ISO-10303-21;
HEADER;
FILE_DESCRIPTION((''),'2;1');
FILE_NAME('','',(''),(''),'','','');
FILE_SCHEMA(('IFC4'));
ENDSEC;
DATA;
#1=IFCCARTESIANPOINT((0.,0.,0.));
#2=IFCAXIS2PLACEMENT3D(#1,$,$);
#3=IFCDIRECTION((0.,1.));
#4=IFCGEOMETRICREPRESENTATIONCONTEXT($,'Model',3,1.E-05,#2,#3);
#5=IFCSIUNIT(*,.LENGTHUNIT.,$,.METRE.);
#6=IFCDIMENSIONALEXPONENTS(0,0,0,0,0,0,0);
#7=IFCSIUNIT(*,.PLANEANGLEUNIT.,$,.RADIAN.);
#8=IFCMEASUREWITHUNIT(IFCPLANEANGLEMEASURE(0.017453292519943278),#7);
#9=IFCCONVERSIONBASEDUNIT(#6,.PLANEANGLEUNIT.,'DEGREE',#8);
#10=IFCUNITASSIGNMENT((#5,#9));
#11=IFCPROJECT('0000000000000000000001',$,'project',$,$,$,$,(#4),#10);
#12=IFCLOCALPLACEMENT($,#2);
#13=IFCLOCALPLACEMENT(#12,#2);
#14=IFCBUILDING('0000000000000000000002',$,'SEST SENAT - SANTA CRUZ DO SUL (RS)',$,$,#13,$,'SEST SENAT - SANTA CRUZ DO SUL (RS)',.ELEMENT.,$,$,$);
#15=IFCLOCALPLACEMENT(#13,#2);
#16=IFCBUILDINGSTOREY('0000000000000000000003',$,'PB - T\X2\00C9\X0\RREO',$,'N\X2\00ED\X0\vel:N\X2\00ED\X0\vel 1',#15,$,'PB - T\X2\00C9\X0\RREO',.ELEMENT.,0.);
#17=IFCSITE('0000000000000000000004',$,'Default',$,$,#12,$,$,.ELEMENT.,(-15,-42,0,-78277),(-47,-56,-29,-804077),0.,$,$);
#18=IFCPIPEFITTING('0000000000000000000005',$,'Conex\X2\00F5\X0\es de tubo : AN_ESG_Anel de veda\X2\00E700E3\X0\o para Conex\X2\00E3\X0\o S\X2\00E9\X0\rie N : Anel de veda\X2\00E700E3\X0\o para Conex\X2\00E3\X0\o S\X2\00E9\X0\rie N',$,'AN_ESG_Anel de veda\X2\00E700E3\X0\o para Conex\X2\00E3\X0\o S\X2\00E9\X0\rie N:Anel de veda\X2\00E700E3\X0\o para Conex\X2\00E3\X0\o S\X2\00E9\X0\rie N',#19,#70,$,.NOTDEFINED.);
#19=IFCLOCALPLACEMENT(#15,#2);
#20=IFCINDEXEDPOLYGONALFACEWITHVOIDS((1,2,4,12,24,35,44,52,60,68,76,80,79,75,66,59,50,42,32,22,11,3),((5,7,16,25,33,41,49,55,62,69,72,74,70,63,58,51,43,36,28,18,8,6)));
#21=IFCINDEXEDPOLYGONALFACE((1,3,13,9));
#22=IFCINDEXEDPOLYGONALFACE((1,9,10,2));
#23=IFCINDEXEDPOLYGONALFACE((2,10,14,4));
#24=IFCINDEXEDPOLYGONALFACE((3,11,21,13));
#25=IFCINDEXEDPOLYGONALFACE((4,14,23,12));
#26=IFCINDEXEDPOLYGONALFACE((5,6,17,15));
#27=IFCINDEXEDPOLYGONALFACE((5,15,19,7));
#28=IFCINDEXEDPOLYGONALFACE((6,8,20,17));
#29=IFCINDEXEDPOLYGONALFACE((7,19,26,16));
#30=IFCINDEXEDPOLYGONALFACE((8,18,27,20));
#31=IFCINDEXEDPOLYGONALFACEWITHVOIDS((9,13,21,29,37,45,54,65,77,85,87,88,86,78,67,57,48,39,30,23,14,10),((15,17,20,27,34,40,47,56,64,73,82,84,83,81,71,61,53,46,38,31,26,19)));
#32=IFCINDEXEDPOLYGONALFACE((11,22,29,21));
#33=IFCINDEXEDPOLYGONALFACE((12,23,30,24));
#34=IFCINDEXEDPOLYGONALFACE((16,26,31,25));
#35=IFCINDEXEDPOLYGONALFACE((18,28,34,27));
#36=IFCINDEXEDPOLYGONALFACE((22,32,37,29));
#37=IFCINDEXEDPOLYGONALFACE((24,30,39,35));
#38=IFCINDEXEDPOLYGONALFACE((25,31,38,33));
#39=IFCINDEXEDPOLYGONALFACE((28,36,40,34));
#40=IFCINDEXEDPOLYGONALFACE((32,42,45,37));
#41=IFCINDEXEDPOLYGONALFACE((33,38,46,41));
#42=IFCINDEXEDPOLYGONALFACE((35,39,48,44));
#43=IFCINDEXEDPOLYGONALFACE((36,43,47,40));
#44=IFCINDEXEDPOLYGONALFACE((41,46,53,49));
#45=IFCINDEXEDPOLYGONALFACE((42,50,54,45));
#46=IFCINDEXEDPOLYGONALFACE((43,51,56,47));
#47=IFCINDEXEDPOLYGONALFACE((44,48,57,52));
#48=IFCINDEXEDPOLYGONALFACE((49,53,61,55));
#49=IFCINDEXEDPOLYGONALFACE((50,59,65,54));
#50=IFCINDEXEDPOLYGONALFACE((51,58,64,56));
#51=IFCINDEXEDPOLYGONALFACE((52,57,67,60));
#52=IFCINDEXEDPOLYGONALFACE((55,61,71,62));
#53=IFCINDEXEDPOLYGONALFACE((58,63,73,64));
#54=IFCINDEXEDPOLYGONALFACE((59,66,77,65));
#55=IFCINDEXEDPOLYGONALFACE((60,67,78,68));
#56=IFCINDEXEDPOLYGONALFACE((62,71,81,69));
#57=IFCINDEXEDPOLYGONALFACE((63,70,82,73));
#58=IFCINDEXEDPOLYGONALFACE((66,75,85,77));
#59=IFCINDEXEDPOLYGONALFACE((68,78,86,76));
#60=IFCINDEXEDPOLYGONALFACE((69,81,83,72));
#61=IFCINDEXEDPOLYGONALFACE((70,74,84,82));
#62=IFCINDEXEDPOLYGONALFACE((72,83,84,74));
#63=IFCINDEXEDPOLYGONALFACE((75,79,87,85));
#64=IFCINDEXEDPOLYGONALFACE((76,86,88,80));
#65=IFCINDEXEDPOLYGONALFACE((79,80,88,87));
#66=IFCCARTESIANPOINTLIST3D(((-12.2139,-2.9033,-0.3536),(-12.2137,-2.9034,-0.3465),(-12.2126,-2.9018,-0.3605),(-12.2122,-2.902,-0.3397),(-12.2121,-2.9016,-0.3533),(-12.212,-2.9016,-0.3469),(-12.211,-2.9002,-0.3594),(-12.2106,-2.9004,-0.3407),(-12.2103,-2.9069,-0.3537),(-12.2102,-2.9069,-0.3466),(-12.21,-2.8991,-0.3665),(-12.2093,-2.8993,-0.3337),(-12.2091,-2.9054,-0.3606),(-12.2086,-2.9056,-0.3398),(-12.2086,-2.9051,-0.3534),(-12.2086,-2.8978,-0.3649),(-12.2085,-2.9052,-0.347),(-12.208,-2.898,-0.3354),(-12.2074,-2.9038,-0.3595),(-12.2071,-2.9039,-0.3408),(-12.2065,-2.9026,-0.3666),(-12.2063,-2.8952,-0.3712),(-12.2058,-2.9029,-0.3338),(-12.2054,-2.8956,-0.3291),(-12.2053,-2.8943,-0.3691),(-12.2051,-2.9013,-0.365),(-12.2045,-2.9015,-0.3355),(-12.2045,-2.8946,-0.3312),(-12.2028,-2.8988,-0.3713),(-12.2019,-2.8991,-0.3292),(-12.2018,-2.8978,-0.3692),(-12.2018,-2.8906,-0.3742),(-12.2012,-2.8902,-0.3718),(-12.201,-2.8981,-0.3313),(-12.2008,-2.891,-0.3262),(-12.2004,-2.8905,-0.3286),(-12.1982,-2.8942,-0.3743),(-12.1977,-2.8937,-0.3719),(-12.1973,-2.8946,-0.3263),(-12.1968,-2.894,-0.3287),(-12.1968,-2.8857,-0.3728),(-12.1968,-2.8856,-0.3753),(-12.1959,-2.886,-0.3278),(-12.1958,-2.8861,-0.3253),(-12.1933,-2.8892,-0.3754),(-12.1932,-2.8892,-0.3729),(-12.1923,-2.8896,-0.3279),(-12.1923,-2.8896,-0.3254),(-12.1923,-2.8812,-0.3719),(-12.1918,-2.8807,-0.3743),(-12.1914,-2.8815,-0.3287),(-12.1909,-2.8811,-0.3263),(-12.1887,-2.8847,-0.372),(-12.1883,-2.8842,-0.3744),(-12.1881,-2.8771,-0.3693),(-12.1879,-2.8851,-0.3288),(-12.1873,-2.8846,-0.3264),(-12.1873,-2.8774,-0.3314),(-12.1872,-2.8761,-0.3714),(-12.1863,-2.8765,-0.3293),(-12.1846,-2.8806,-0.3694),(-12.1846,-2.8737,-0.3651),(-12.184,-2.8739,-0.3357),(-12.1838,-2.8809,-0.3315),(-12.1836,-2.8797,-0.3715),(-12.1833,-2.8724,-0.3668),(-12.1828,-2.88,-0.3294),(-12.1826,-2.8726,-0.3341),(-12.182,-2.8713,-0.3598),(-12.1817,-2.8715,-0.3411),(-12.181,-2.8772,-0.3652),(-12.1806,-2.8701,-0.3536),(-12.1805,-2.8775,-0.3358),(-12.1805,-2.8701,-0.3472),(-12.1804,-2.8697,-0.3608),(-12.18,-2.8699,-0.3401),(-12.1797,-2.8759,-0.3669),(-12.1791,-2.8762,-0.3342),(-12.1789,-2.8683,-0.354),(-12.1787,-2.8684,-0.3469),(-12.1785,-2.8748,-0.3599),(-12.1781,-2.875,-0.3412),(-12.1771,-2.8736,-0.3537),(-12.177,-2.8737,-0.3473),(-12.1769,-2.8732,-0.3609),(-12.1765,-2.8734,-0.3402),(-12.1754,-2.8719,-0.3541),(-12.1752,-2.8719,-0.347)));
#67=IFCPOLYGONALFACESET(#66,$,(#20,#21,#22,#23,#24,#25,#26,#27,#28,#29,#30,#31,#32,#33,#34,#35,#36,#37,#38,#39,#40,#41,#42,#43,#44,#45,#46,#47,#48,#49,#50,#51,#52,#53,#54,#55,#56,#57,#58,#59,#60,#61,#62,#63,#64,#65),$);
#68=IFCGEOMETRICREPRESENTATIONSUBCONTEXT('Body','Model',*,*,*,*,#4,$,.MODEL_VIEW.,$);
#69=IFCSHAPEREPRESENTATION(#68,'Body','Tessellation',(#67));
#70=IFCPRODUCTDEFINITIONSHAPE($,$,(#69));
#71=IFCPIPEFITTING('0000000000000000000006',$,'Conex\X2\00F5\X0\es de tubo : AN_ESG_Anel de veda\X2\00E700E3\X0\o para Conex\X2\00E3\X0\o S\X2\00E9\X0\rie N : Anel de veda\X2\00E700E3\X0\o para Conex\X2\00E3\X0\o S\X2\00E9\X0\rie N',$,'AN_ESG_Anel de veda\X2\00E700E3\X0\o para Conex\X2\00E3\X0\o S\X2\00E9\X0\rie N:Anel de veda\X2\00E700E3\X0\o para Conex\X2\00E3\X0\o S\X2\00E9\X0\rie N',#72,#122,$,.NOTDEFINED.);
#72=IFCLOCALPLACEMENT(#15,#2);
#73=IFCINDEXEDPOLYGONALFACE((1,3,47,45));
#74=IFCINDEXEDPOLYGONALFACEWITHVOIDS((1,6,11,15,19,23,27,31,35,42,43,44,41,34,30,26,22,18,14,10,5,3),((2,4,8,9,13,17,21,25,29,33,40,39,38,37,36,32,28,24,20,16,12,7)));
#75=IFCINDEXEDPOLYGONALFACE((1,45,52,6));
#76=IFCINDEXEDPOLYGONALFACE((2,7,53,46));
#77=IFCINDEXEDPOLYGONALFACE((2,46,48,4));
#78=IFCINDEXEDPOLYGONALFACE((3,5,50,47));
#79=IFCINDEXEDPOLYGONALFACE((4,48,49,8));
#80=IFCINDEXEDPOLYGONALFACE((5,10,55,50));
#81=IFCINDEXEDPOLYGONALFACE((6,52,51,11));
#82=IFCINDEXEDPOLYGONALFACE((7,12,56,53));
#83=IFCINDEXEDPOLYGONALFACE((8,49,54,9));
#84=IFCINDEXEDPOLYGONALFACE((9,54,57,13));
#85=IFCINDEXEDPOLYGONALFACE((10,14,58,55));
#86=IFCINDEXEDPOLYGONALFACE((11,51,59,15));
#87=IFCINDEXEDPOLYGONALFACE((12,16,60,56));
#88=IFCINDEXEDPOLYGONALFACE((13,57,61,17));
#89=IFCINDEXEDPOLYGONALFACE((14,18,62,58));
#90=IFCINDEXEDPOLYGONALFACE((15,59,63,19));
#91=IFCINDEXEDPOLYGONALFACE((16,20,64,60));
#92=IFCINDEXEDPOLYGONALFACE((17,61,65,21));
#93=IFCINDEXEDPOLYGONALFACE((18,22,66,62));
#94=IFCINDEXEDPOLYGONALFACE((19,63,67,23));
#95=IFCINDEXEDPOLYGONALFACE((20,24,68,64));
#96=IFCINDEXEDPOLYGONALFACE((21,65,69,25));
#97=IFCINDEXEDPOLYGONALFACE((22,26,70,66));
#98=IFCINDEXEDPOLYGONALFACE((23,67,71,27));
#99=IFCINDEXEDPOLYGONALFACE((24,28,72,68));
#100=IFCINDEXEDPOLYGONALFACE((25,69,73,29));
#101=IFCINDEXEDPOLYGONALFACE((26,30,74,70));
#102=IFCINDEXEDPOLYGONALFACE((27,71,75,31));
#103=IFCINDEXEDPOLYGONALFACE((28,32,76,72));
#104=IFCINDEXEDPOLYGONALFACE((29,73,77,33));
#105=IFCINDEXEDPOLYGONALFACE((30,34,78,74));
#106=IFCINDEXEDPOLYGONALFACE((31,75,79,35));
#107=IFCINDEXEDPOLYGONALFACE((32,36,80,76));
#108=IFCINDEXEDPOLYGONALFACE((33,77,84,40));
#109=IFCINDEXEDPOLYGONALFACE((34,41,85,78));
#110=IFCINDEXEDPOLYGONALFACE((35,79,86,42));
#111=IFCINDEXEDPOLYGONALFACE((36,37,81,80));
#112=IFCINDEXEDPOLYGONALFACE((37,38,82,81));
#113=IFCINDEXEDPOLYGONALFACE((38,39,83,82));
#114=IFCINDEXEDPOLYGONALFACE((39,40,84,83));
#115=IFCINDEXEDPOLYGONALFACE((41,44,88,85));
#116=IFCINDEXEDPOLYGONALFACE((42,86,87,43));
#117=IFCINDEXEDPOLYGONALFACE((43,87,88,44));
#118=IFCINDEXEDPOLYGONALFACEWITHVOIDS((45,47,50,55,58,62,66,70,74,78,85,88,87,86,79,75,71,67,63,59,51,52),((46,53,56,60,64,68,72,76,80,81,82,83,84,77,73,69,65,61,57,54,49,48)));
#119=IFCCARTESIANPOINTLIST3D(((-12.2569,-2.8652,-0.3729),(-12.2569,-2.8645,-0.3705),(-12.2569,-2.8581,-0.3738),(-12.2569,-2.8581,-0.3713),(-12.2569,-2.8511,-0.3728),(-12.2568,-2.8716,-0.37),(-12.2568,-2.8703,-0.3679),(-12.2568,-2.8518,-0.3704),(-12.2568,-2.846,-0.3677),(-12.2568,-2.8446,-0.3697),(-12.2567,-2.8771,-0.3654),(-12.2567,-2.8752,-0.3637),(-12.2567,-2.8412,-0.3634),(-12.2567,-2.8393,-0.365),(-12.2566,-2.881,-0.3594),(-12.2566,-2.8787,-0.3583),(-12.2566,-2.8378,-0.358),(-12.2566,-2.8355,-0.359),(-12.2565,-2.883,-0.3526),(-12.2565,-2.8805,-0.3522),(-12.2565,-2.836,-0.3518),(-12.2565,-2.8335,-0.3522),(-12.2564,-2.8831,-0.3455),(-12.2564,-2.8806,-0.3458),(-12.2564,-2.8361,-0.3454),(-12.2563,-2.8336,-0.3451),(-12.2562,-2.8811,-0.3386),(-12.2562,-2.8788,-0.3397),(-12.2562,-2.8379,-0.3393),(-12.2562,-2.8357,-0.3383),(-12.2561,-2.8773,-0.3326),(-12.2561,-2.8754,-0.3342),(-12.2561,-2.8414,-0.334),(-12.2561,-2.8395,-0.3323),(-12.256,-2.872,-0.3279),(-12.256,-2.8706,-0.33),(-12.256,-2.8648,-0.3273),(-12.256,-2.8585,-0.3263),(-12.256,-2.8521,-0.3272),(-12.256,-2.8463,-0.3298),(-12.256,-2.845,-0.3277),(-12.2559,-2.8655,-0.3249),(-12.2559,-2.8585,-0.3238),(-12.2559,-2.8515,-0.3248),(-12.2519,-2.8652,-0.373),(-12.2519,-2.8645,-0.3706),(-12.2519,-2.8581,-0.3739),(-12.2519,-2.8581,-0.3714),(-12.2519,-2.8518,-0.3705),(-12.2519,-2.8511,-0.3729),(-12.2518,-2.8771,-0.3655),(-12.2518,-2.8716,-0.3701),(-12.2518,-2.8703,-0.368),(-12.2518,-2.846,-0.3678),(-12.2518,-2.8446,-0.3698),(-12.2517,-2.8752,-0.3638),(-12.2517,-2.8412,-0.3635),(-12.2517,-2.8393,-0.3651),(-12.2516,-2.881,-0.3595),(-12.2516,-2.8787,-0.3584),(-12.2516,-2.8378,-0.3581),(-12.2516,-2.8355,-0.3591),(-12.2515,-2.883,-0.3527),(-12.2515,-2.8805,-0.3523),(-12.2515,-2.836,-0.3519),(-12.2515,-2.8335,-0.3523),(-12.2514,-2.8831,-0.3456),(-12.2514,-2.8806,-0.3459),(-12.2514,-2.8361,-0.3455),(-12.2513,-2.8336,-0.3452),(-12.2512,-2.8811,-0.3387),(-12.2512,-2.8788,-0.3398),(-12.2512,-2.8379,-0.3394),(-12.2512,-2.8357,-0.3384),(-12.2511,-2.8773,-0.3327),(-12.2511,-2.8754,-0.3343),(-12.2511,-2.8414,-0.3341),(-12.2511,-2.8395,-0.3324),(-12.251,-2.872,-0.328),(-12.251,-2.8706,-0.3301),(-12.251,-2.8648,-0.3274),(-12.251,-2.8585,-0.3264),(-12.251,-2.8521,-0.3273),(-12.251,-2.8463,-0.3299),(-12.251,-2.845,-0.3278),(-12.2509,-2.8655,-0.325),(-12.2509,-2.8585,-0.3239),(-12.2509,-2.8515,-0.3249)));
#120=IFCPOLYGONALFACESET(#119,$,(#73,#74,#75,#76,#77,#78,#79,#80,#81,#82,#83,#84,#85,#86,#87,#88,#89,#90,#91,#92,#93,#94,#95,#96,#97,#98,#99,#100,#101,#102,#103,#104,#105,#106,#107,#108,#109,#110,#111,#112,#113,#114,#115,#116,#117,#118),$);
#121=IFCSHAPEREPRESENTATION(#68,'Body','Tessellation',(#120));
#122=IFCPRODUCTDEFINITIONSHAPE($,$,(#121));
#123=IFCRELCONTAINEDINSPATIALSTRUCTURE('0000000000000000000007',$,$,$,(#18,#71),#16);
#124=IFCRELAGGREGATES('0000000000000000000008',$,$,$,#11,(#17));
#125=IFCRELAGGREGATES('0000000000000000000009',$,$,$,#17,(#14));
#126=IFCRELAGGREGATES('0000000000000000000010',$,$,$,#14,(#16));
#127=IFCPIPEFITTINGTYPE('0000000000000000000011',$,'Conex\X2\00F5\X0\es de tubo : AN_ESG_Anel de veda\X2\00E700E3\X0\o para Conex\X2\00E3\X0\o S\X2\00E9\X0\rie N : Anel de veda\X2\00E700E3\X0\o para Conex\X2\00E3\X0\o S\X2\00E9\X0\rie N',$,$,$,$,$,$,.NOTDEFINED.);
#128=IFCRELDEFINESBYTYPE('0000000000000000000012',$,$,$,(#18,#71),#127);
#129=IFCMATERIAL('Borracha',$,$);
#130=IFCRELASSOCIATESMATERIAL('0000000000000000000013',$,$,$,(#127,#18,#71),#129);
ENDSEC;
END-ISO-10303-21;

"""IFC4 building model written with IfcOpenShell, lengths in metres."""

from ifc_helpers import new_model, entity, si_unit, converted_unit, direction, frame, origin, place, context, subcontext, project, spatial, arc, indexed_curve, outline, extrude, source, transform, mapped, material, type_object, type_shapes, element, save


model = new_model("IFC4")

# Units and contexts
model_context = context("Model", 3, precision=1e-05, world=origin(), true_north=direction((0.0, 1.0)))
body_context = subcontext(model_context, "Body", "Model", "MODEL_VIEW")
ifc_project = project(units=[si_unit("LENGTHUNIT", "METRE"), converted_unit("PLANEANGLEUNIT", "DEGREE", entity("IfcPlaneAngleMeasure", 0.017453292519943278), si_unit("PLANEANGLEUNIT", "RADIAN"), dimensions=[0, 0, 0, 0, 0, 0, 0])], contexts=[model_context])

# Site, building, storey
site_placement = place(None, origin())
site = spatial("IfcSite", under=ifc_project, at=site_placement, Name="Default", CompositionType="ELEMENT", RefLatitude=(-15, -42, 0, -78277), RefLongitude=(-47, -56, -29, -804077), RefElevation=0.0)
building_placement = place(site_placement, origin())
building = spatial("IfcBuilding", under=site, at=building_placement, Name="SEST SENAT - SANTA CRUZ DO SUL (RS)", LongName="SEST SENAT - SANTA CRUZ DO SUL (RS)", CompositionType="ELEMENT")
storey_placement = place(building_placement, origin())
storey = spatial("IfcBuildingStorey", under=building, at=storey_placement, Name="PB - TÉRREO", ObjectType="Nível:Nível 1", LongName="PB - TÉRREO", CompositionType="ELEMENT", Elevation=0.0)

# Pipe fittings
ifc_material = material(Name="Borracha")
pipe_fitting_type_1 = type_object("IfcPipeFittingType", Name="Conexões de tubo : AN_ESG_Anel de vedação para Conexão Série N : Anel de vedação para Conexão Série N", PredefinedType="NOTDEFINED", material=ifc_material)
shared_shape_1 = source(origin(), body_context, "Body", "SweptSolid", [
    extrude(outline(indexed_curve([(-0.025, 0.0), (0.0, -0.025), (0.025, 0.0), (0.0, 0.025)], segments=[arc(1, 2, 3), arc(3, 4, 1)], self_intersect=False), holes=[indexed_curve([(-0.0225, 0.0), (0.0, 0.0225), (0.0225, 0.0), (0.0, -0.0225)], segments=[arc(1, 2, 3), arc(3, 4, 1)], self_intersect=False)]), frame((0.0, 0.0, -0.005)), (0.0, 0.0, 1.0), 0.005),
])
type_shapes(pipe_fitting_type_1, [shared_shape_1])
for number, where, z_axis, x_axis, name in (
    (1, (-12.1928, -2.8894, -0.3504), (0.707036, -0.706895, -0.019996), (0.019995, -0.008281, 0.999766), "Conexões de tubo : AN_ESG_Anel de vedação para Conexão Série N : Anel de vedação para Conexão Série N"),
    (2, (-12.2514, -2.8583, -0.3489), (0.9998, 0.0, -0.019996), (0.019995, -0.008281, 0.999766), "Conexões de tubo : AN_ESG_Anel de vedação para Conexão Série N : Anel de vedação para Conexão Série N"),
):
    element("IfcPipeFitting", number, at=place(storey_placement, frame(where, z_axis=z_axis, x_axis=x_axis)), inside=storey, type_object=pipe_fitting_type_1, material=ifc_material, Name=name, ObjectType="AN_ESG_Anel de vedação para Conexão Série N:Anel de vedação para Conexão Série N", PredefinedType="NOTDEFINED", context=body_context, shape_type="MappedRepresentation", body=[
        mapped(shared_shape_1, transform((0.0, 0.0, 0.0), scale=1.0)),
    ])

save(model, "model.ifc")
